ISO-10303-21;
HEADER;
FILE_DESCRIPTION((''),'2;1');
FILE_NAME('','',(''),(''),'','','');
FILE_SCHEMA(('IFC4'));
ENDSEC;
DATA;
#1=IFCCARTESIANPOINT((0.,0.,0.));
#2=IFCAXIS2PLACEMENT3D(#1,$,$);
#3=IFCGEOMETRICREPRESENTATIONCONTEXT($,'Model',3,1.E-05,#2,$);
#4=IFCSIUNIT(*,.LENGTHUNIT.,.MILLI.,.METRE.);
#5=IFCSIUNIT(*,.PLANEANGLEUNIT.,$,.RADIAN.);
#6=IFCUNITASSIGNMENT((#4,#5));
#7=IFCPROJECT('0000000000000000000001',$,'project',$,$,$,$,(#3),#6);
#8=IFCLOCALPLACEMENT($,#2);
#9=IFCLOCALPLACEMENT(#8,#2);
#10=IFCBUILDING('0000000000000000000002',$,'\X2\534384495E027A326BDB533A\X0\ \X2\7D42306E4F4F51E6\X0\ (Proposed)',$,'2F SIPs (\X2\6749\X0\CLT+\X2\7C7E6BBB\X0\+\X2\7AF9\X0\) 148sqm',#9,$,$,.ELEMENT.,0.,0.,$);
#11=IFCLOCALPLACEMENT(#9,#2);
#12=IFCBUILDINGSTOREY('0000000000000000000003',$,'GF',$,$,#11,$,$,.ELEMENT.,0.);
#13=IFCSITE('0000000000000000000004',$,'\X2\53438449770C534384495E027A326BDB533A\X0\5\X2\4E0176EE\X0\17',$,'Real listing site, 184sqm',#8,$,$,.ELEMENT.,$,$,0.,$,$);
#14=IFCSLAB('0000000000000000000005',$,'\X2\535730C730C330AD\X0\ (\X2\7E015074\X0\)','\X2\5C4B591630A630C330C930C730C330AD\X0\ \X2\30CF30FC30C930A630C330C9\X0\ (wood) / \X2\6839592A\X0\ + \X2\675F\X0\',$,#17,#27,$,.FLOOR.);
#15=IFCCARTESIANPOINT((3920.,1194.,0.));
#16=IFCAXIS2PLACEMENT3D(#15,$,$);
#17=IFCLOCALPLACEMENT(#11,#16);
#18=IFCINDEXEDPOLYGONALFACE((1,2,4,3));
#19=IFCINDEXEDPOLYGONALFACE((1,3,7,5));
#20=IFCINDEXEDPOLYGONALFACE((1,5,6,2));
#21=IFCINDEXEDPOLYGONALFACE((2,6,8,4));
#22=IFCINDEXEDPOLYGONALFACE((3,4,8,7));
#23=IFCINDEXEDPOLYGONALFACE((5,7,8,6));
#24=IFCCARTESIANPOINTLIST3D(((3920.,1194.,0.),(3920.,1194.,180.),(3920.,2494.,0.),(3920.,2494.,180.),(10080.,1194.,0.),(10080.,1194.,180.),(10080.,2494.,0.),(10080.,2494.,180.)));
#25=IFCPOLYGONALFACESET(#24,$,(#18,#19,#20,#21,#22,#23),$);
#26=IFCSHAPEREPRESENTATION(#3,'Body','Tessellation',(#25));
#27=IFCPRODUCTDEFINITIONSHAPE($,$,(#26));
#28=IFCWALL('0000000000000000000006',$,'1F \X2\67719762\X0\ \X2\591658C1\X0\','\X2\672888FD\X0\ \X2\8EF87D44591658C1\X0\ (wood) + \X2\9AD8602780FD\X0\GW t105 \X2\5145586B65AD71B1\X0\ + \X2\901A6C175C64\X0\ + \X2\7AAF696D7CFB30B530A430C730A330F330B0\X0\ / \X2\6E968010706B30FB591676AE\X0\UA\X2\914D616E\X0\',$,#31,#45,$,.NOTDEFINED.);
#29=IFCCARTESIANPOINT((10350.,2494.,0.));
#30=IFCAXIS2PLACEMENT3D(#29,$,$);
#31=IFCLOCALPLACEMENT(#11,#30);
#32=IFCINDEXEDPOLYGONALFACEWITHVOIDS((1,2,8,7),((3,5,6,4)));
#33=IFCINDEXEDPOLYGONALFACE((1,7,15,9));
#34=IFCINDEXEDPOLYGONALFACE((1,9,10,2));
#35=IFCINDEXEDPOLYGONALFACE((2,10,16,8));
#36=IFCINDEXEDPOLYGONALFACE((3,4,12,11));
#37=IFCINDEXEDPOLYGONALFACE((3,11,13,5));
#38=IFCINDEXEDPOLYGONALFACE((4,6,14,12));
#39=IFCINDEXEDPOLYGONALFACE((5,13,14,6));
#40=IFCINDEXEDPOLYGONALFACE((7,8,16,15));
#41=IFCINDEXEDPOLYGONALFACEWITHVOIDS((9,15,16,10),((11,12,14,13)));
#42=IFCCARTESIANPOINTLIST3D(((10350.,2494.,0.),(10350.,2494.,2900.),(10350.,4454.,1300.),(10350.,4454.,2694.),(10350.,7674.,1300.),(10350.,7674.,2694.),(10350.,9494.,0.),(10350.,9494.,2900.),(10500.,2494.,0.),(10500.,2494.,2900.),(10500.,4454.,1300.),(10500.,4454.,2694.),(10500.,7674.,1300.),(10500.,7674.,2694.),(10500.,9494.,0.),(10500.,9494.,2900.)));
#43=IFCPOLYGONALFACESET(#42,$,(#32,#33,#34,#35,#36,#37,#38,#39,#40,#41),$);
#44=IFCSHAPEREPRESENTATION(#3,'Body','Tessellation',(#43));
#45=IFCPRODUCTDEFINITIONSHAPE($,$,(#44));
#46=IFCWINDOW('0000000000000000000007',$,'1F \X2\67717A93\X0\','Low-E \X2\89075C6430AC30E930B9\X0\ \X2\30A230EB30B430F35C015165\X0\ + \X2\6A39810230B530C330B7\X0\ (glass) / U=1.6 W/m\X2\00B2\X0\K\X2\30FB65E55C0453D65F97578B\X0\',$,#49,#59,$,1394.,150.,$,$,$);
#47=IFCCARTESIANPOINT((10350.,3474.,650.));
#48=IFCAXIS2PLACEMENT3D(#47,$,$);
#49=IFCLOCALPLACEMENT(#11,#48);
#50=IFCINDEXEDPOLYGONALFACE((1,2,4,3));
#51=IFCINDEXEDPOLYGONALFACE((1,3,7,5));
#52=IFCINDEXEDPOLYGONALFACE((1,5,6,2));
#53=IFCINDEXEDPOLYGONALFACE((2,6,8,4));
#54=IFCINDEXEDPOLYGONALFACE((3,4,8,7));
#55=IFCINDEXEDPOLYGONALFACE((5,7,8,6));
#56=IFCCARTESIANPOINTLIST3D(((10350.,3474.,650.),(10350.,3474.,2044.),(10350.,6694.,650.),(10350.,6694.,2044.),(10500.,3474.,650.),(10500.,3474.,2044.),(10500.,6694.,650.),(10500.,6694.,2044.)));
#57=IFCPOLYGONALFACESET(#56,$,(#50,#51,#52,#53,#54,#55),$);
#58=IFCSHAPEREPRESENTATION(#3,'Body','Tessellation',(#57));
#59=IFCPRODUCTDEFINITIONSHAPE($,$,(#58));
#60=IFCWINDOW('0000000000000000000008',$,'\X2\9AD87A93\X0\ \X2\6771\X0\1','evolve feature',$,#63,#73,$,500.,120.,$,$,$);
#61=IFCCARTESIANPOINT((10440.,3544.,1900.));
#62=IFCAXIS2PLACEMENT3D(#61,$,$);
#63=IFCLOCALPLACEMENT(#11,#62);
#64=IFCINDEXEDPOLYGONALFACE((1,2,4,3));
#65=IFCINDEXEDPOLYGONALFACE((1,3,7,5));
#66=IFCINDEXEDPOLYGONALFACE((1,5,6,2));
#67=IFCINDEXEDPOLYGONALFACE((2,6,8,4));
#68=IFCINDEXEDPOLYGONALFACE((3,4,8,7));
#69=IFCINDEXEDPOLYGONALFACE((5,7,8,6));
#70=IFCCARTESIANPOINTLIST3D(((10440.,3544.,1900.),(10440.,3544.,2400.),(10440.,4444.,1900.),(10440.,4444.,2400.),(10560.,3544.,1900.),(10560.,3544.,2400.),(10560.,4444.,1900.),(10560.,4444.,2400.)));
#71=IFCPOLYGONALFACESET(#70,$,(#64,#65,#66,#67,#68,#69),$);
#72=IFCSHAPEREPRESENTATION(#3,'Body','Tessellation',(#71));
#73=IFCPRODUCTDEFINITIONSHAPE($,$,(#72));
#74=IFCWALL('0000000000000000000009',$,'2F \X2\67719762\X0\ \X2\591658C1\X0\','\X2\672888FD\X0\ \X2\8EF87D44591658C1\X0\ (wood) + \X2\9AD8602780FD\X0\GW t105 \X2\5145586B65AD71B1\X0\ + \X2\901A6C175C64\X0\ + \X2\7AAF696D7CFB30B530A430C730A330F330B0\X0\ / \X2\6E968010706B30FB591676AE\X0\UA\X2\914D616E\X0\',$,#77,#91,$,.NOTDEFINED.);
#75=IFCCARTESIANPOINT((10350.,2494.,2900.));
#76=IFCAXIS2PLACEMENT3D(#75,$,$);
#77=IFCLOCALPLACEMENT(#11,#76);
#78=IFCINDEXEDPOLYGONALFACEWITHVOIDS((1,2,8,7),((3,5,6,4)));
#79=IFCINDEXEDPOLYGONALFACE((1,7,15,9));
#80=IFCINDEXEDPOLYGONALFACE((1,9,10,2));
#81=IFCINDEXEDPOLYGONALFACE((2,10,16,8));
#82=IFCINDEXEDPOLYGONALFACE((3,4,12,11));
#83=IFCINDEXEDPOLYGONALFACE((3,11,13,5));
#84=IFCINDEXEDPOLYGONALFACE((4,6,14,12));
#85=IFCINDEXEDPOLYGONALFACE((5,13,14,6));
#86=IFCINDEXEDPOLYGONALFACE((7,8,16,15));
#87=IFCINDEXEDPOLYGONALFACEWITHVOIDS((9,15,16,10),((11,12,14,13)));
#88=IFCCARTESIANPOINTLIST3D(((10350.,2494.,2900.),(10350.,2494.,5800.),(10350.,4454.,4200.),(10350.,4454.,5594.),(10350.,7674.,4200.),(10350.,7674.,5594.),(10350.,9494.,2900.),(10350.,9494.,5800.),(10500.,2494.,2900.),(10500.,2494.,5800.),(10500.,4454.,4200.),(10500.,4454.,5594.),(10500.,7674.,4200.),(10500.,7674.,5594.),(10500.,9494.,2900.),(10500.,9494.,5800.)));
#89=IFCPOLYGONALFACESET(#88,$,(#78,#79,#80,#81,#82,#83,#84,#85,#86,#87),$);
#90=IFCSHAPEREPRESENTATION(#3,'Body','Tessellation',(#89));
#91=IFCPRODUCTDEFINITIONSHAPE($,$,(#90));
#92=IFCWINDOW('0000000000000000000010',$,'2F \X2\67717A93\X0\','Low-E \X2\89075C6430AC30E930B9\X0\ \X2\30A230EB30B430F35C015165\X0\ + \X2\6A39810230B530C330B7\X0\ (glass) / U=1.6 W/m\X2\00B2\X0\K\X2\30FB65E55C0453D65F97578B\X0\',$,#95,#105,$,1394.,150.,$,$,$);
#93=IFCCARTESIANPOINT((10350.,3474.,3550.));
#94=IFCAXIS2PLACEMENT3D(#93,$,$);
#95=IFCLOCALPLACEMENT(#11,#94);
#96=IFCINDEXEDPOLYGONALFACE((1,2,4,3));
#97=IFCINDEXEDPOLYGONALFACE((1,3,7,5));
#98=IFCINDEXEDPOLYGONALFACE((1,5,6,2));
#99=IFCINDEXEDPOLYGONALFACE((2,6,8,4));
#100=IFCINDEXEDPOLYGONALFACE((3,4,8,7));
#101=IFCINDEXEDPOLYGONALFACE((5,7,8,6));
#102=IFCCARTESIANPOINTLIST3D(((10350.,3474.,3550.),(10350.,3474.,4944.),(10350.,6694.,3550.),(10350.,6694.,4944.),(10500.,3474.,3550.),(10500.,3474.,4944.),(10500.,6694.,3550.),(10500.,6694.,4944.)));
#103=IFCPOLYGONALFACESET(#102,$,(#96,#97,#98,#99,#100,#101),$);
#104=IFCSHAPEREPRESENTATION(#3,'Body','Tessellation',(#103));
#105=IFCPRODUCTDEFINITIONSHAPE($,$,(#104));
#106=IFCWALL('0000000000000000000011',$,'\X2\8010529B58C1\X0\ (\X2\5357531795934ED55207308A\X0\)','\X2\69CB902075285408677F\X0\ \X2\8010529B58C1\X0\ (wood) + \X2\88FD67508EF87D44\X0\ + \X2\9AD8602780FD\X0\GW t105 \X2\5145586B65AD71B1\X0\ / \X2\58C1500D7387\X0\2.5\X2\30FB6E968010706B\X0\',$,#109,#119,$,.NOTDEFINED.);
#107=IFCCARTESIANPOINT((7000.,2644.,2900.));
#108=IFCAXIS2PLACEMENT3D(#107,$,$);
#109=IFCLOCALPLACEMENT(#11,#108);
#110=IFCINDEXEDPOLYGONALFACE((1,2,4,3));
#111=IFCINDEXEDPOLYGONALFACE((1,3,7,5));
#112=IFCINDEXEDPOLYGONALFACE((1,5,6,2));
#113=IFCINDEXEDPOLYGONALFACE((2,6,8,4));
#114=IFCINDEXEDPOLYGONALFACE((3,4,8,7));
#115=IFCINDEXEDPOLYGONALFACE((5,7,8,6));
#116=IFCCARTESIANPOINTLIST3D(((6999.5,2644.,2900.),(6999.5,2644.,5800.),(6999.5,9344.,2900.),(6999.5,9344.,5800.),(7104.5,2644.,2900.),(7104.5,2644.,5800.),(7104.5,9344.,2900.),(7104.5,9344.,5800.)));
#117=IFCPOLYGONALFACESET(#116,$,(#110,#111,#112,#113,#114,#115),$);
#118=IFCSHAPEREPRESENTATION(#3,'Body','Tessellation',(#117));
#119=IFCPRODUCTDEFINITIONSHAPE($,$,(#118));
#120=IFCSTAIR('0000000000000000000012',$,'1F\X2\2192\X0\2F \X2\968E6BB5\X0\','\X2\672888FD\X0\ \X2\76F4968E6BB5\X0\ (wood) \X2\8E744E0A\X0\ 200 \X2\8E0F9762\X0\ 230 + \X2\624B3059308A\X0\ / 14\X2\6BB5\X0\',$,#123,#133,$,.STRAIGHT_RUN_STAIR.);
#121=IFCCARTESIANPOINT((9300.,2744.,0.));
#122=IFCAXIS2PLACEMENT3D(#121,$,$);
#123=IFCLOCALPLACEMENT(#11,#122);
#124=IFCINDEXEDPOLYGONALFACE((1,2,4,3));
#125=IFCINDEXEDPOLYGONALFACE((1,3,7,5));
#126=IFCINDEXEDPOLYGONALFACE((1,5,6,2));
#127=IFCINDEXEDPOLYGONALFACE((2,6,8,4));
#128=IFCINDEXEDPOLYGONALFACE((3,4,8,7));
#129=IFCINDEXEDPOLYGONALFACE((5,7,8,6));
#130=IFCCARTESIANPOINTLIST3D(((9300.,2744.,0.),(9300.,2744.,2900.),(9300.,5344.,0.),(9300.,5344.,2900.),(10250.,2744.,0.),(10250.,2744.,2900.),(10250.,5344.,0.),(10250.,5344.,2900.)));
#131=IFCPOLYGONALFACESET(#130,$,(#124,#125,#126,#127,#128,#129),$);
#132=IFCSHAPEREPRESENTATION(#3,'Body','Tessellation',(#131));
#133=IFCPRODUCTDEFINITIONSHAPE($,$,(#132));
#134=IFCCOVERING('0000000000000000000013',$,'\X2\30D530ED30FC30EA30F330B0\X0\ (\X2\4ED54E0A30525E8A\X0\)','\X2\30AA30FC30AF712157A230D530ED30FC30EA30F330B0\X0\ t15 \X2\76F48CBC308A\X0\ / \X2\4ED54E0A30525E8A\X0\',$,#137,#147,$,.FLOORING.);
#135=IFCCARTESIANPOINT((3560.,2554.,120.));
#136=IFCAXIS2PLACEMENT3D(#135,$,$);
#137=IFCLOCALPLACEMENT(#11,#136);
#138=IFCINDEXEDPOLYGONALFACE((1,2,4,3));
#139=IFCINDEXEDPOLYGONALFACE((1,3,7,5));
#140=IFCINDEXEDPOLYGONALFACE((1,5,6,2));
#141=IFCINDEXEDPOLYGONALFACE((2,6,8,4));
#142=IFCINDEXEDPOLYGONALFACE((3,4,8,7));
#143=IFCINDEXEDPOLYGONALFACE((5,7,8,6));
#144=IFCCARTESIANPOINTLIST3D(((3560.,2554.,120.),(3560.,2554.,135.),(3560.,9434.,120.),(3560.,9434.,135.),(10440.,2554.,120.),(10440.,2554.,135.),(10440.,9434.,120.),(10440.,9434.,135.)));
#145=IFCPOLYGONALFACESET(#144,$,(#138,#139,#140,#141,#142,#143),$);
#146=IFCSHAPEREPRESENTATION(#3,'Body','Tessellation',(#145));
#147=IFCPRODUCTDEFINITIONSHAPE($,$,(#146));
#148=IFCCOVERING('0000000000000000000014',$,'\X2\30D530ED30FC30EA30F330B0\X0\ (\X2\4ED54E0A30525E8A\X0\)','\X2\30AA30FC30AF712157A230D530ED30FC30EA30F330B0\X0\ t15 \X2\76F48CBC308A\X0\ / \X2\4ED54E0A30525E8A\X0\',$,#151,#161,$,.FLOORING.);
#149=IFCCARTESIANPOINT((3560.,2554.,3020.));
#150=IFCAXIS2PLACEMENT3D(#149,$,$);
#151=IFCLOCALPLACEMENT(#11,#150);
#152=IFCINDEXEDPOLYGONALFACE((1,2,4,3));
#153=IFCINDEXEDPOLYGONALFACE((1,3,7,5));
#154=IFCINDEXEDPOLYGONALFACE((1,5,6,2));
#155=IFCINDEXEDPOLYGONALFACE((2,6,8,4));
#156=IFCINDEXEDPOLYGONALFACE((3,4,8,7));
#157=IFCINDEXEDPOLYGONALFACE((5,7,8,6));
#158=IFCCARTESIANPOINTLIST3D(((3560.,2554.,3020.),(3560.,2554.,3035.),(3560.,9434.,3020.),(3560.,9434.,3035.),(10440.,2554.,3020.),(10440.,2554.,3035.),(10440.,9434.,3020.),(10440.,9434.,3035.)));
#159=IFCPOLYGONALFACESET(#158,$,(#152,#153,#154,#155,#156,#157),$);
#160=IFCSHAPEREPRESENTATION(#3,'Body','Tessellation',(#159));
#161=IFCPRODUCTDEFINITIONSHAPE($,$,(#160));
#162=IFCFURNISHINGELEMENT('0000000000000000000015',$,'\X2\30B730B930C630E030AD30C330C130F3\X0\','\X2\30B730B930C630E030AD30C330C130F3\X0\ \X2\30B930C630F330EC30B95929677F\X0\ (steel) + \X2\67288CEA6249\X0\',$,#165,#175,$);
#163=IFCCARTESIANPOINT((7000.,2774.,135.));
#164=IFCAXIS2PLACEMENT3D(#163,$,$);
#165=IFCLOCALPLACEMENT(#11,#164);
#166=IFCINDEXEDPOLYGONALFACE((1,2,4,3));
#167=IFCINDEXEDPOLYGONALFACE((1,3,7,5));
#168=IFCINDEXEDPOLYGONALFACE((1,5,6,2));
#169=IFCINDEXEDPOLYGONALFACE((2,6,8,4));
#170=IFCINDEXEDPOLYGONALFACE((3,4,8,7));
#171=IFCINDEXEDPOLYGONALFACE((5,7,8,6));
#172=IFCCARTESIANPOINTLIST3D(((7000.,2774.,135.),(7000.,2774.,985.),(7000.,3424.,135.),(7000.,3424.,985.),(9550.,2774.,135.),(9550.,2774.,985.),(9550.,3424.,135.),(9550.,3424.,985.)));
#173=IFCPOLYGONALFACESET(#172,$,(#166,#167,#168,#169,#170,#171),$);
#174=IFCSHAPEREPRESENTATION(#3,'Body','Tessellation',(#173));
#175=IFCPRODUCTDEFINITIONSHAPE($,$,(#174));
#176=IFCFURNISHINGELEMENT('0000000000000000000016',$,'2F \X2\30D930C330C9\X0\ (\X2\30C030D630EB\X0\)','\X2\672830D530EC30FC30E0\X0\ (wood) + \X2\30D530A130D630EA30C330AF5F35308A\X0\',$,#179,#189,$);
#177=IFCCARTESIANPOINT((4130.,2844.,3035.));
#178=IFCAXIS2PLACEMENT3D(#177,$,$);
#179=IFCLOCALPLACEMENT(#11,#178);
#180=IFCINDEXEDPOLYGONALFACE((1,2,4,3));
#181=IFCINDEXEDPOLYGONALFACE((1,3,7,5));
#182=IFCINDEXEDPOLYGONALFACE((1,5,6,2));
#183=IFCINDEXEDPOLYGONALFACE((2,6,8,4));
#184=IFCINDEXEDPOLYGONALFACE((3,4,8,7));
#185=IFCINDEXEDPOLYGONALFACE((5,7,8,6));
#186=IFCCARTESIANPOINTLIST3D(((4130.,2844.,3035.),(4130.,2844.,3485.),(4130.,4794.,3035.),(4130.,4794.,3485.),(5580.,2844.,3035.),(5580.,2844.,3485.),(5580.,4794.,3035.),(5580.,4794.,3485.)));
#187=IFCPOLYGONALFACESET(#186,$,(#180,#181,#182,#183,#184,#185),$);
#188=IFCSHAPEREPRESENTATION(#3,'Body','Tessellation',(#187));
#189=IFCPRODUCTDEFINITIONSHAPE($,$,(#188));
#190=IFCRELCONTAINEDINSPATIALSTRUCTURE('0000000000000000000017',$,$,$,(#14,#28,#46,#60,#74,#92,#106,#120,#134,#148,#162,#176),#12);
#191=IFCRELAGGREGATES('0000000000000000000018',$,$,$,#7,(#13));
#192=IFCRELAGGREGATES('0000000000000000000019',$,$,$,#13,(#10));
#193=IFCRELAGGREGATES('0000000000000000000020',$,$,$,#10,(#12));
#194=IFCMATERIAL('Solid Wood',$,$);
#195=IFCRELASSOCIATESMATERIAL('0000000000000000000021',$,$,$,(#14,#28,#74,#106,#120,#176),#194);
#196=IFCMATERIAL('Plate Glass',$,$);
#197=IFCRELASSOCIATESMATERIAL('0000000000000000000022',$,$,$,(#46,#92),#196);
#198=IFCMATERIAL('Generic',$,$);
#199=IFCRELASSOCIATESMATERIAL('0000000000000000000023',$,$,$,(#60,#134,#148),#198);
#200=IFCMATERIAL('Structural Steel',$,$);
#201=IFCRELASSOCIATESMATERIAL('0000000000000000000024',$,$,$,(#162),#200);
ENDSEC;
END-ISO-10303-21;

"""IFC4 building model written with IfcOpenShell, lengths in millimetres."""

from ifc_helpers import new_model, si_unit, frame, frame_2d, origin, place, context, project, spatial, rectangle, extrude, material, element, fill, save


model = new_model("IFC4")

# Units and contexts
model_context = context("Model", 3, precision=1e-05, world=origin())
ifc_project = project(units=[si_unit("LENGTHUNIT", "METRE", prefix="MILLI"), si_unit("PLANEANGLEUNIT", "RADIAN")], contexts=[model_context])

# Site, building, storey
site_placement = place(None, origin())
site = spatial("IfcSite", under=ifc_project, at=site_placement, Name="千葉県千葉市稲毛区5丁目17", ObjectType="Real listing site, 184sqm", CompositionType="ELEMENT", RefElevation=0.0)
building_placement = place(site_placement, origin())
building = spatial("IfcBuilding", under=site, at=building_placement, Name="千葉市稲毛区 終の住処 (Proposed)", ObjectType="2F SIPs (杉CLT+籾殻+竹) 148sqm", CompositionType="ELEMENT", ElevationOfRefHeight=0.0, ElevationOfTerrain=0.0)
storey_placement = place(building_placement, origin())
storey = spatial("IfcBuildingStorey", under=building, at=storey_placement, Name="GF", CompositionType="ELEMENT", Elevation=0.0)

# Slab
ifc_material_1 = material(Name="Solid Wood")
slab_placement = place(storey_placement, frame((3920.0, 1194.0, 0.0)))
element("IfcSlab", 1, at=slab_placement, inside=storey, material=ifc_material_1, Name="南デッキ (縁側)", Description="屋外ウッドデッキ ハードウッド (wood) / 根太 + 束", PredefinedType="FLOOR", context=model_context, shape_type="SweptSolid", body=[
    extrude(rectangle(XDim=6160.0, YDim=1300.0, at=frame_2d((3080.0, 650.0))), frame((3920.0, 1194.0, 0.0)), (0.0, 0.0, 1.0), 180.0),
])

# Wall, openings, windows
wall_1_placement = place(storey_placement, frame((10350.0, 2494.0, 0.0)))
wall_1 = element("IfcWall", 2, at=wall_1_placement, inside=storey, material=ifc_material_1, Name="1F 東面 外壁", Description="木製 軸組外壁 (wood) + 高性能GW t105 充填断熱 + 通気層 + 窯業系サイディング / 準耐火・外皮UA配慮", PredefinedType="NOTDEFINED", context=model_context, shape_type="SweptSolid", body=[
    extrude(rectangle(XDim=150.0, YDim=7000.0, at=frame_2d((75.0, 3500.0))), frame((10350.0, 2494.0, 0.0)), (0.0, 0.0, 1.0), 2900.0),
])
opening_1_placement = place(storey_placement, frame((10350.0, 3474.0, 650.0)))
opening_1 = element("IfcOpeningElement", 3, at=opening_1_placement, cuts=wall_1, PredefinedType="NOTDEFINED", context=model_context, shape_type="SweptSolid", body=[
    extrude(rectangle(XDim=150.0, YDim=3220.0, at=frame_2d((75.0, 1610.0))), frame((10350.0, 3474.0, 650.0)), (0.0, 0.0, 1.0), 1394.0),
])
opening_2_placement = place(storey_placement, frame((10440.0, 3544.0, 1900.0)))
opening_2 = element("IfcOpeningElement", 4, at=opening_2_placement, cuts=wall_1, PredefinedType="NOTDEFINED", context=model_context, shape_type="SweptSolid", body=[
    extrude(rectangle(XDim=120.0, YDim=900.0, at=frame_2d((60.0, 450.0))), frame((10440.0, 3544.0, 1900.0)), (0.0, 0.0, 1.0), 500.0),
])
ifc_material_2 = material(Name="Plate Glass")
window_1_placement = place(storey_placement, frame((10350.0, 3474.0, 650.0)))
window_1 = element("IfcWindow", 5, at=window_1_placement, inside=storey, material=ifc_material_2, Name="1F 東窓", Description="Low-E 複層ガラス アルゴン封入 + 樹脂サッシ (glass) / U=1.6 W/m²K・日射取得型", OverallHeight=1394.0, OverallWidth=150.0, context=model_context, shape_type="SweptSolid", body=[
    extrude(rectangle(XDim=150.0, YDim=3220.0, at=frame_2d((75.0, 1610.0))), frame((10350.0, 3474.0, 650.0)), (0.0, 0.0, 1.0), 1394.0),
])
fill(opening_1, window_1)
ifc_material_3 = material(Name="Generic")
window_2_placement = place(storey_placement, frame((10440.0, 3544.0, 1900.0)))
window_2 = element("IfcWindow", 6, at=window_2_placement, inside=storey, material=ifc_material_3, Name="高窓 東1", Description="evolve feature", OverallHeight=500.0, OverallWidth=120.0, context=model_context, shape_type="SweptSolid", body=[
    extrude(rectangle(XDim=120.0, YDim=900.0, at=frame_2d((60.0, 450.0))), frame((10440.0, 3544.0, 1900.0)), (0.0, 0.0, 1.0), 500.0),
])
fill(opening_2, window_2)

# Wall, opening, window
wall_2_placement = place(storey_placement, frame((10350.0, 2494.0, 2900.0)))
wall_2 = element("IfcWall", 7, at=wall_2_placement, inside=storey, material=ifc_material_1, Name="2F 東面 外壁", Description="木製 軸組外壁 (wood) + 高性能GW t105 充填断熱 + 通気層 + 窯業系サイディング / 準耐火・外皮UA配慮", PredefinedType="NOTDEFINED", context=model_context, shape_type="SweptSolid", body=[
    extrude(rectangle(XDim=150.0, YDim=7000.0, at=frame_2d((75.0, 3500.0))), frame((10350.0, 2494.0, 2900.0)), (0.0, 0.0, 1.0), 2900.0),
])
opening_3_placement = place(storey_placement, frame((10350.0, 3474.0, 3550.0)))
opening_3 = element("IfcOpeningElement", 8, at=opening_3_placement, cuts=wall_2, PredefinedType="NOTDEFINED", context=model_context, shape_type="SweptSolid", body=[
    extrude(rectangle(XDim=150.0, YDim=3220.0, at=frame_2d((75.0, 1610.0))), frame((10350.0, 3474.0, 3550.0)), (0.0, 0.0, 1.0), 1394.0),
])
window_3_placement = place(storey_placement, frame((10350.0, 3474.0, 3550.0)))
window_3 = element("IfcWindow", 9, at=window_3_placement, inside=storey, material=ifc_material_2, Name="2F 東窓", Description="Low-E 複層ガラス アルゴン封入 + 樹脂サッシ (glass) / U=1.6 W/m²K・日射取得型", OverallHeight=1394.0, OverallWidth=150.0, context=model_context, shape_type="SweptSolid", body=[
    extrude(rectangle(XDim=150.0, YDim=3220.0, at=frame_2d((75.0, 1610.0))), frame((10350.0, 3474.0, 3550.0)), (0.0, 0.0, 1.0), 1394.0),
])
fill(opening_3, window_3)

# Wall
wall_3_placement = place(storey_placement, frame((7000.0, 2644.0, 2900.0)))
element("IfcWall", 10, at=wall_3_placement, inside=storey, material=ifc_material_1, Name="耐力壁 (南北間仕切り)", Description="構造用合板 耐力壁 (wood) + 製材軸組 + 高性能GW t105 充填断熱 / 壁倍率2.5・準耐火", PredefinedType="NOTDEFINED", context=model_context, shape_type="SweptSolid", body=[
    extrude(rectangle(XDim=105.0, YDim=6700.0, at=frame_2d((52.0, 3350.0))), frame((7000.0, 2644.0, 2900.0)), (0.0, 0.0, 1.0), 2900.0),
])

# Stair
stair_placement = place(storey_placement, frame((9300.0, 2744.0, 0.0)))
element("IfcStair", 11, at=stair_placement, inside=storey, material=ifc_material_1, Name="1F→2F 階段", Description="木製 直階段 (wood) 蹴上 200 踏面 230 + 手すり / 14段", PredefinedType="STRAIGHT_RUN_STAIR", context=model_context, shape_type="SweptSolid", body=[
    extrude(rectangle(XDim=950.0, YDim=2600.0, at=frame_2d((475.0, 1300.0))), frame((9300.0, 2744.0, 0.0)), (0.0, 0.0, 1.0), 2900.0),
])

# Coverings
covering_1_placement = place(storey_placement, frame((3560.0, 2554.0, 120.0)))
element("IfcCovering", 12, at=covering_1_placement, inside=storey, material=ifc_material_3, Name="フローリング (仕上げ床)", Description="オーク無垢フローリング t15 直貼り / 仕上げ床", PredefinedType="FLOORING", context=model_context, shape_type="SweptSolid", body=[
    extrude(rectangle(XDim=6880.0, YDim=6880.0, at=frame_2d((3440.0, 3440.0))), frame((3560.0, 2554.0, 120.0)), (0.0, 0.0, 1.0), 15.0),
])
covering_2_placement = place(storey_placement, frame((3560.0, 2554.0, 3020.0)))
element("IfcCovering", 13, at=covering_2_placement, inside=storey, material=ifc_material_3, Name="フローリング (仕上げ床)", Description="オーク無垢フローリング t15 直貼り / 仕上げ床", PredefinedType="FLOORING", context=model_context, shape_type="SweptSolid", body=[
    extrude(rectangle(XDim=6880.0, YDim=6880.0, at=frame_2d((3440.0, 3440.0))), frame((3560.0, 2554.0, 3020.0)), (0.0, 0.0, 1.0), 15.0),
])

# Furnishing elements
ifc_material_4 = material(Name="Structural Steel")
furnishing_1_placement = place(storey_placement, frame((7000.0, 2774.0, 135.0)))
element("IfcFurnishingElement", 14, at=furnishing_1_placement, inside=storey, material=ifc_material_4, Name="システムキッチン", Description="システムキッチン ステンレス天板 (steel) + 木質扉", context=model_context, shape_type="SweptSolid", body=[
    extrude(rectangle(XDim=2550.0, YDim=650.0, at=frame_2d((1275.0, 325.0))), frame((7000.0, 2774.0, 135.0)), (0.0, 0.0, 1.0), 850.0),
])
furnishing_2_placement = place(storey_placement, frame((4130.0, 2844.0, 3035.0)))
element("IfcFurnishingElement", 15, at=furnishing_2_placement, inside=storey, material=ifc_material_1, Name="2F ベッド (ダブル)", Description="木フレーム (wood) + ファブリック張り", context=model_context, shape_type="SweptSolid", body=[
    extrude(rectangle(XDim=1450.0, YDim=1950.0, at=frame_2d((725.0, 975.0))), frame((4130.0, 2844.0, 3035.0)), (0.0, 0.0, 1.0), 450.0),
])

save(model, "model.ifc")
